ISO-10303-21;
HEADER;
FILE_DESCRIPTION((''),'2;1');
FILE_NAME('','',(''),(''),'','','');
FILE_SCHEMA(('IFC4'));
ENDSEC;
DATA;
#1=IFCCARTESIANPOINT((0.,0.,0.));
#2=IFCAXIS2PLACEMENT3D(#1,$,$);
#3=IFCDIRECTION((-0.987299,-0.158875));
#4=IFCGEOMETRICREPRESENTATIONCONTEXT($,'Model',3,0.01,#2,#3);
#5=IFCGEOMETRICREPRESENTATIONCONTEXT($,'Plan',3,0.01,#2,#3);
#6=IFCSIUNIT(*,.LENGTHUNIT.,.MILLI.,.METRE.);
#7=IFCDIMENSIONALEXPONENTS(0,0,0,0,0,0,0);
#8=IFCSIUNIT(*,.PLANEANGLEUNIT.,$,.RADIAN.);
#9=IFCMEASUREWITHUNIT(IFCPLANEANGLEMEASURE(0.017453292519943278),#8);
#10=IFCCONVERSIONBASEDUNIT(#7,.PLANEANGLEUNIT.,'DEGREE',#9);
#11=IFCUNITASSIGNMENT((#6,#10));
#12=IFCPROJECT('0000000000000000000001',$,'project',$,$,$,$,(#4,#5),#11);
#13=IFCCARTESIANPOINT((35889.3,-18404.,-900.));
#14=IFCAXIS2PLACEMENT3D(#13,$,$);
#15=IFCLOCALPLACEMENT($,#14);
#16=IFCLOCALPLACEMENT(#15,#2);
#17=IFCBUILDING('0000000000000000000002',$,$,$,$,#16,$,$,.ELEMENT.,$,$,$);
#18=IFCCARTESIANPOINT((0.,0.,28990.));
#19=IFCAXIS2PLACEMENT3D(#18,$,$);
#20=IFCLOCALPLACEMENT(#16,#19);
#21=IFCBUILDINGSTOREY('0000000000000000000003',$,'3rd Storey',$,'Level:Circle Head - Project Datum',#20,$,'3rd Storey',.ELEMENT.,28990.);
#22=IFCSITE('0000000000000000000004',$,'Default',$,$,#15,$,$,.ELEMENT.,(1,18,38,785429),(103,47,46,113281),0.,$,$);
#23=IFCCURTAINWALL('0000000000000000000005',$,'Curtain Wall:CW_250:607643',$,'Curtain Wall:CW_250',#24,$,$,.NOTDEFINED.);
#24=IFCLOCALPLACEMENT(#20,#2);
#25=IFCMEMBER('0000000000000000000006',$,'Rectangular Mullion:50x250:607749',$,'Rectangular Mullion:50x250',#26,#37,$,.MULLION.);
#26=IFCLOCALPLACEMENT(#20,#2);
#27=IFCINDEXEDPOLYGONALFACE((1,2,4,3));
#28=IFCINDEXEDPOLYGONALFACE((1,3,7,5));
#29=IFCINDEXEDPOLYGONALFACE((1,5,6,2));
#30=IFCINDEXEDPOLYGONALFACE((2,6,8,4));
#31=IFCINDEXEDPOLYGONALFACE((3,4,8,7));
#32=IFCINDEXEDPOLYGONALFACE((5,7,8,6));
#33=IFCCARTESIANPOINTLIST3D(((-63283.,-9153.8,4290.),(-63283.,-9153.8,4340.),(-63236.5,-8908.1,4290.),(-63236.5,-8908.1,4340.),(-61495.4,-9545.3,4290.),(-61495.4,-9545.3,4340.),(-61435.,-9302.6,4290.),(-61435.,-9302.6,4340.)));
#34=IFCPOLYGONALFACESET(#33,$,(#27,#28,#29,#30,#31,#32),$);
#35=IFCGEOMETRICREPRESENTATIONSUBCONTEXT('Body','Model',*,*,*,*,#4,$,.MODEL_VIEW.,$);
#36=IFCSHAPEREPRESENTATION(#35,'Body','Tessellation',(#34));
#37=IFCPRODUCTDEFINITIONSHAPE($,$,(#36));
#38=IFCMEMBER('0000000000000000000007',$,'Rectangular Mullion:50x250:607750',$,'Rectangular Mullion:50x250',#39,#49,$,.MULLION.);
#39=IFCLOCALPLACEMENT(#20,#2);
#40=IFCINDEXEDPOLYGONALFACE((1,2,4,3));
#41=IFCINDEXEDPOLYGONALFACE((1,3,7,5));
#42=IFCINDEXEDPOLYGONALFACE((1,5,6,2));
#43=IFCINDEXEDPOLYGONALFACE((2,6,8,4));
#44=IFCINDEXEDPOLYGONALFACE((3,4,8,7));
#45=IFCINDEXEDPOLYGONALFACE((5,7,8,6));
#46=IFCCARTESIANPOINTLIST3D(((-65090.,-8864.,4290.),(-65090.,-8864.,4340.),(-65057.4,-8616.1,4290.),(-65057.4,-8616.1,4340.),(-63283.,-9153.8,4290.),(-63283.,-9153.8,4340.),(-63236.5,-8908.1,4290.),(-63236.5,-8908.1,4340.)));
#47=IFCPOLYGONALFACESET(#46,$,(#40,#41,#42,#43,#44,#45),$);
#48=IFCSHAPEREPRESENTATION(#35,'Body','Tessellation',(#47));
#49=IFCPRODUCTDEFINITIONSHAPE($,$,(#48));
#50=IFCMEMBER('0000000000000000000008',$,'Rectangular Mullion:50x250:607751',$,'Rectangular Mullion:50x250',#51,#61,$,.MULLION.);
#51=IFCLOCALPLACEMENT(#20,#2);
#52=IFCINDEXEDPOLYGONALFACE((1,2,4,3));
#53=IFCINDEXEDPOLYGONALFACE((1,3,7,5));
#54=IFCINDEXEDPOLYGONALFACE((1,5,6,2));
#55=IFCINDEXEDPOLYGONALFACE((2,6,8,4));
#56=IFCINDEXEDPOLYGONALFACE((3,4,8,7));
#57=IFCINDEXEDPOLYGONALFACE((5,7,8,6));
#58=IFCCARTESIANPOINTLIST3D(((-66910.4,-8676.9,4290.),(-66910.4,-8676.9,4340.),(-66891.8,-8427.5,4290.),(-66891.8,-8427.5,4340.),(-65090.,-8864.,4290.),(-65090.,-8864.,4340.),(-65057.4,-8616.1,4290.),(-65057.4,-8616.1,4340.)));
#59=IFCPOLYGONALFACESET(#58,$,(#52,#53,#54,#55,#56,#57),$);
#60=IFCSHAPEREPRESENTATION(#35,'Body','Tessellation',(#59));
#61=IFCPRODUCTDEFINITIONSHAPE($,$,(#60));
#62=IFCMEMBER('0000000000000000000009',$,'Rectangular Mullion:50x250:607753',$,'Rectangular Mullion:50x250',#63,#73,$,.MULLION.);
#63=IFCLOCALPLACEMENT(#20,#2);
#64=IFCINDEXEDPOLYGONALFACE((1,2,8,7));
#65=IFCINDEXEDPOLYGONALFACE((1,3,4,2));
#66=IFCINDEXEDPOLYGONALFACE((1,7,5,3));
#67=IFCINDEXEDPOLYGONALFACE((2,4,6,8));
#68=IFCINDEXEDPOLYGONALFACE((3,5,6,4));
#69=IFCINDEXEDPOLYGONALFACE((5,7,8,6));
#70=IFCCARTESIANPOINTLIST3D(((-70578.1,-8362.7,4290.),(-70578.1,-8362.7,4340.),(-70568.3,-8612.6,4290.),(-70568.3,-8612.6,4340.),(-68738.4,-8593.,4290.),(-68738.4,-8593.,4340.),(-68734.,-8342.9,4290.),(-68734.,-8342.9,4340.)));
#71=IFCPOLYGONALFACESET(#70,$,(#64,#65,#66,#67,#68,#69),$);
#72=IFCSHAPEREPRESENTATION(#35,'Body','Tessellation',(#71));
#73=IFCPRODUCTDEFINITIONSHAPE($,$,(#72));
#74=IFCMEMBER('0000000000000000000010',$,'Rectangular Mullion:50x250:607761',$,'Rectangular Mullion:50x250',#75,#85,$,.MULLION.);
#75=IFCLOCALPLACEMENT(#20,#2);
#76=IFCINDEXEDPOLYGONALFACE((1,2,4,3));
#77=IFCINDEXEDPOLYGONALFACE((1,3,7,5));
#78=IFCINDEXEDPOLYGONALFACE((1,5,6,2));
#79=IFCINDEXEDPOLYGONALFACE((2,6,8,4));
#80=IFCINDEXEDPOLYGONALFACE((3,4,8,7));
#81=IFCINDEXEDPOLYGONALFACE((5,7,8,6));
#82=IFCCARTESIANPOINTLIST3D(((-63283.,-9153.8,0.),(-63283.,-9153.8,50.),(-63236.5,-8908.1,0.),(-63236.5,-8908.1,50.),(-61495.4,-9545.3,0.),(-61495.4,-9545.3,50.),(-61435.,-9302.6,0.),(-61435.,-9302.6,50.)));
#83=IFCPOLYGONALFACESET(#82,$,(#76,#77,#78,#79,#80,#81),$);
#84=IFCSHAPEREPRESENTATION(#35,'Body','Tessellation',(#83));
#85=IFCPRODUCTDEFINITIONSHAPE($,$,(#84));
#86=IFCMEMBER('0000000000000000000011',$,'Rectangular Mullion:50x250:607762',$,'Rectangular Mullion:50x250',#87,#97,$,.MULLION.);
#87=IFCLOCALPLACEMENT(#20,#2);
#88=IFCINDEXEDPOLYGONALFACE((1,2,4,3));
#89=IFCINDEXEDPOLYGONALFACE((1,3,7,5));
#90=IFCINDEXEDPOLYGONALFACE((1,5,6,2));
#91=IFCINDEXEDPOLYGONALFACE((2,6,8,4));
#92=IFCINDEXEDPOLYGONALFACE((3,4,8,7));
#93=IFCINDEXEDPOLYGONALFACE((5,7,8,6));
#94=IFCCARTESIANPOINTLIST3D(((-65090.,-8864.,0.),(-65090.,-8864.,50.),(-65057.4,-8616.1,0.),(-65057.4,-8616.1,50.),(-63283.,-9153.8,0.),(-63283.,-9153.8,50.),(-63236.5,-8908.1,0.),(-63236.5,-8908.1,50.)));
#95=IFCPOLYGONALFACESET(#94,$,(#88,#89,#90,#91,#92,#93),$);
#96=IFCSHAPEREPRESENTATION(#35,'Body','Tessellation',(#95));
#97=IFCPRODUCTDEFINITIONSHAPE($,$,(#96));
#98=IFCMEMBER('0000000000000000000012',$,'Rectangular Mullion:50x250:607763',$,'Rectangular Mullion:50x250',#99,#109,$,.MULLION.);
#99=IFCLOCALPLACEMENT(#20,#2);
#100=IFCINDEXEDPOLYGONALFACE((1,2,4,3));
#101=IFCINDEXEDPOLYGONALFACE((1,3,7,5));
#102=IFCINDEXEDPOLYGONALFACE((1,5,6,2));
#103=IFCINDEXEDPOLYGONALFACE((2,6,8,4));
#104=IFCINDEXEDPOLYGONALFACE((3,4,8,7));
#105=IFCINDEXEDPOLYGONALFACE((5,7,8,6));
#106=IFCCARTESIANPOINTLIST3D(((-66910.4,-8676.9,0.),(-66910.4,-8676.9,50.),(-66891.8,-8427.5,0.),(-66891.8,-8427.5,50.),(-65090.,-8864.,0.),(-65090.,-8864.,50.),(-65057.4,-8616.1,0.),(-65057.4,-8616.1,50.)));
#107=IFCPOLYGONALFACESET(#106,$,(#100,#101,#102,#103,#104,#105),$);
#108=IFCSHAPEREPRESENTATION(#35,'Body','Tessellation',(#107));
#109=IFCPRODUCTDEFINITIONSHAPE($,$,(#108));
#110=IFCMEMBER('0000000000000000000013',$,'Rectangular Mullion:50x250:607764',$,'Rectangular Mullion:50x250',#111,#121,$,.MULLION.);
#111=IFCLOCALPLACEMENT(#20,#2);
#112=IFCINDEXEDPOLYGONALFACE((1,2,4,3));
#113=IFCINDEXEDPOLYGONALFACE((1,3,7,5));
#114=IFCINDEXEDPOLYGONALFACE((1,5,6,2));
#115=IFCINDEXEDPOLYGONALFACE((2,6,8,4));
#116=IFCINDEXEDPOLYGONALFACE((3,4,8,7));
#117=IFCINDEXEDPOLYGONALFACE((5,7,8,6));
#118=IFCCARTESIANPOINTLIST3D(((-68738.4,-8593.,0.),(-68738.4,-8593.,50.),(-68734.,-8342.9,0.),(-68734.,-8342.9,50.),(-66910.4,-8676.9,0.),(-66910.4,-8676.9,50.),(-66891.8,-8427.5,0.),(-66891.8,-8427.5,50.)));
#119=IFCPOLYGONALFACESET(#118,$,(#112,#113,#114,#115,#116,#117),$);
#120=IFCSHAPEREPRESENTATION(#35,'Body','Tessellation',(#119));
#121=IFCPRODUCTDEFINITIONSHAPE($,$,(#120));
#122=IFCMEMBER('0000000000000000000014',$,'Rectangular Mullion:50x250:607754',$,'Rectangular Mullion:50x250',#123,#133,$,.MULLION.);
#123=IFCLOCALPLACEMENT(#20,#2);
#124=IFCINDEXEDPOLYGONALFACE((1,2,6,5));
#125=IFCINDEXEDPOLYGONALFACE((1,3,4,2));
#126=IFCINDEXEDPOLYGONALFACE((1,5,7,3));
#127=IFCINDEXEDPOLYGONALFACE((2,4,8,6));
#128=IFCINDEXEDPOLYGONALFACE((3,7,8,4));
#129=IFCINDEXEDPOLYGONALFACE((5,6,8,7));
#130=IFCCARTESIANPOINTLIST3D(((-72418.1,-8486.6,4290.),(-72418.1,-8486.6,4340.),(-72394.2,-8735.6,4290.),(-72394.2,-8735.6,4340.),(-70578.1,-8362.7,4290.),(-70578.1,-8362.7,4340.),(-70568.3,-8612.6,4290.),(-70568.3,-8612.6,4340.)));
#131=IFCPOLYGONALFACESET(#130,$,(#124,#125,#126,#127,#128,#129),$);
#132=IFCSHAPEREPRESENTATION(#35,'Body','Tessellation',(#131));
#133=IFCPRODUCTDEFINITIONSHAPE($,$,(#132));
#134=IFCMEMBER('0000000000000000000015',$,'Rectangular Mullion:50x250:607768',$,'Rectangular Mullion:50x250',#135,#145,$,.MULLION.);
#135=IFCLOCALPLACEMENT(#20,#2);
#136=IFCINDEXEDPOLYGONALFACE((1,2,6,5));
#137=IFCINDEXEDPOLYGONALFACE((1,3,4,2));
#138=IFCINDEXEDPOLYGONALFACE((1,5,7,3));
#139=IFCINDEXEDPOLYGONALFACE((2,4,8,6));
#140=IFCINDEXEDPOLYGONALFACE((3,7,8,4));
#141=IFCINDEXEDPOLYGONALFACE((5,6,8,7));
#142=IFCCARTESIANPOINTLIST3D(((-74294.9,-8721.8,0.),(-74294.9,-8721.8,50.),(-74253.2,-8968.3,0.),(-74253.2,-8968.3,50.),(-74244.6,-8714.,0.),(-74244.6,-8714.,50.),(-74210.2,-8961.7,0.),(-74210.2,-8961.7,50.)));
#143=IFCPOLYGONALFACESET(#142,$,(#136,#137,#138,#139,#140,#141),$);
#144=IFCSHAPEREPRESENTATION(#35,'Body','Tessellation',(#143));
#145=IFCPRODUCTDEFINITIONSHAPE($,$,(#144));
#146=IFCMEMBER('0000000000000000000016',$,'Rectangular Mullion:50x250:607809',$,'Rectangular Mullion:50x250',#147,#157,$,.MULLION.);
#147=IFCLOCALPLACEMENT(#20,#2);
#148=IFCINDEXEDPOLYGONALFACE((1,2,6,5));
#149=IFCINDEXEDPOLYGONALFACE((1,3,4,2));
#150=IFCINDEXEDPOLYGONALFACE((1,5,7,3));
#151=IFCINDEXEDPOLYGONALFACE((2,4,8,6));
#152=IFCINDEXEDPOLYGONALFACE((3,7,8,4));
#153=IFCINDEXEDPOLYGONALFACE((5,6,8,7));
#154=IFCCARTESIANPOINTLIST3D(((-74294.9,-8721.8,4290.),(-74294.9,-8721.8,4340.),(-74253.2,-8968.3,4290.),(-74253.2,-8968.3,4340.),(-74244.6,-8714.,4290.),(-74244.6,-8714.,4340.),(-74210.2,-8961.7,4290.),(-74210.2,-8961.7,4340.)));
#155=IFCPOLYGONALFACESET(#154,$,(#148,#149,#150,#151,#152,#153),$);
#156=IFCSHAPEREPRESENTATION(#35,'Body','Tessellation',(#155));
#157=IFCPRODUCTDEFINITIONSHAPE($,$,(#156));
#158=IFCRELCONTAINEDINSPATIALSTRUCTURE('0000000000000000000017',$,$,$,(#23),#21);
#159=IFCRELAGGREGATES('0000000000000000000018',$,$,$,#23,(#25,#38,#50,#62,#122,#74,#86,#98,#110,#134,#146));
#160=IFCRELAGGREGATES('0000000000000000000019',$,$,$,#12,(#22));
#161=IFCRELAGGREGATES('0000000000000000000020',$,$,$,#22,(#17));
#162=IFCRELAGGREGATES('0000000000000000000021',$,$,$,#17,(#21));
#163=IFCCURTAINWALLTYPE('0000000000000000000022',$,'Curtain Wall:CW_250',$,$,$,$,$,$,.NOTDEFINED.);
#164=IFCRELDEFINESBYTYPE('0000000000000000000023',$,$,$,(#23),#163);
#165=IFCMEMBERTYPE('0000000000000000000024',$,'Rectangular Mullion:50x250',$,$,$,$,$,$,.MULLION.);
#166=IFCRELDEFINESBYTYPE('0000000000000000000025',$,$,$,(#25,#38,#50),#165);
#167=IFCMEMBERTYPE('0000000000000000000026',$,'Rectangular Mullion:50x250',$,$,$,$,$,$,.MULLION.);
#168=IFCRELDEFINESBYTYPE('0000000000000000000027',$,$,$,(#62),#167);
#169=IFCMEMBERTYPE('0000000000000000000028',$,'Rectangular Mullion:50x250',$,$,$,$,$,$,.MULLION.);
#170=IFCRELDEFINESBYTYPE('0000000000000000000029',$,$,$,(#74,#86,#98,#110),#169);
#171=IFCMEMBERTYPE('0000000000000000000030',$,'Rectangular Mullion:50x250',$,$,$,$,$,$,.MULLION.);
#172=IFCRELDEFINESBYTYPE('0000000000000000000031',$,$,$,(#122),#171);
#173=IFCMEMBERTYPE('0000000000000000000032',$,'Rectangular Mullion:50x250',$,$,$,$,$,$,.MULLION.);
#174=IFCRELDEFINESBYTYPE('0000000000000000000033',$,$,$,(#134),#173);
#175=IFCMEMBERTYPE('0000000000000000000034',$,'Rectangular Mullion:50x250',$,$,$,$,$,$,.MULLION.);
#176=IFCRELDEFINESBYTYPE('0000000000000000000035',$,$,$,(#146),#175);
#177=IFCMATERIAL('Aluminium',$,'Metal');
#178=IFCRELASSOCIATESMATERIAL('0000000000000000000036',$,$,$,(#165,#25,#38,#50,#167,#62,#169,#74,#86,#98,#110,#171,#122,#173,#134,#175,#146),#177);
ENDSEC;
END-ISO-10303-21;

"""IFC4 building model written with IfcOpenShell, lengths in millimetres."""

from ifc_helpers import new_model, entity, si_unit, converted_unit, direction, frame, origin, place, context, subcontext, project, spatial, indexed_curve, outline, extrude, source, transform, mapped, material, type_object, type_shapes, element, aggregate, save


model = new_model("IFC4")

# Units and contexts
model_context = context("Model", 3, precision=0.01, world=origin(), true_north=direction((-0.987299, -0.158875)))
plan_context = context("Plan", 3, precision=0.01, world=origin(), true_north=direction((-0.987299, -0.158875)))
body_context = subcontext(model_context, "Body", "Model", "MODEL_VIEW")
ifc_project = project(units=[si_unit("LENGTHUNIT", "METRE", prefix="MILLI"), converted_unit("PLANEANGLEUNIT", "DEGREE", entity("IfcPlaneAngleMeasure", 0.017453292519943278), si_unit("PLANEANGLEUNIT", "RADIAN"), dimensions=[0, 0, 0, 0, 0, 0, 0])], contexts=[model_context, plan_context])

# Site, building, storey
site_placement = place(None, frame((35889.3, -18404.0, -900.0)))
site = spatial("IfcSite", under=ifc_project, at=site_placement, Name="Default", CompositionType="ELEMENT", RefLatitude=(1, 18, 38, 785429), RefLongitude=(103, 47, 46, 113281), RefElevation=0.0)
building_placement = place(site_placement, origin())
building = spatial("IfcBuilding", under=site, at=building_placement, CompositionType="ELEMENT")
storey_placement = place(building_placement, frame((0.0, 0.0, 28990.0)))
storey = spatial("IfcBuildingStorey", under=building, at=storey_placement, Name="3rd Storey", ObjectType="Level:Circle Head - Project Datum", LongName="3rd Storey", CompositionType="ELEMENT", Elevation=28990.0)

# Curtain wall, members
curtain_wall_type = type_object("IfcCurtainWallType", Name="Curtain Wall:CW_250", PredefinedType="NOTDEFINED")
curtain_wall_1_placement = place(storey_placement, frame((0.0, 0.0, -28990.0)))
curtain_wall_1 = element("IfcCurtainWall", 1, at=curtain_wall_1_placement, inside=storey, type_object=curtain_wall_type, Name="Curtain Wall:CW_250:607643", ObjectType="Curtain Wall:CW_250", PredefinedType="NOTDEFINED")
ifc_material_1 = material(Name="Aluminium", Category="Metal")
member_type_1 = type_object("IfcMemberType", Name="Rectangular Mullion:50x250", PredefinedType="MULLION", material=ifc_material_1)
shared_shape_1 = source(origin(), body_context, "Body", "SweptSolid", [
    extrude(outline(indexed_curve([(-915.0, -125.0), (915.0, -125.0), (922.1, 125.0), (-922.1, 125.0), (-915.0, -125.0)], self_intersect=False)), frame((-50.0, 125.0, -915.0), z_axis=(1.0, 0.0, 0.0), x_axis=(0.0, 0.0, -1.0)), (0.0, 0.0, 1.0), 50.0),
])
type_shapes(member_type_1, [shared_shape_1])
member_1_placement = place(curtain_wall_1_placement, frame((-63283.0, -9153.8, 33330.0), z_axis=(-0.976848, 0.213934, 0.0), x_axis=(0.0, 0.0, 1.0)))
member_1 = element("IfcMember", 2, at=member_1_placement, type_object=member_type_1, material=ifc_material_1, Name="Rectangular Mullion:50x250:607749", ObjectType="Rectangular Mullion:50x250", PredefinedType="MULLION", context=body_context, shape_type="MappedRepresentation", body=[
    mapped(shared_shape_1, transform((0.0, 0.0, 0.0), scale=1.0)),
])
member_2_placement = place(curtain_wall_1_placement, frame((-65090.0, -8864.0, 33330.0), z_axis=(-0.987382, 0.158354, 0.0), x_axis=(0.0, 0.0, 1.0)))
member_2 = element("IfcMember", 3, at=member_2_placement, type_object=member_type_1, material=ifc_material_1, Name="Rectangular Mullion:50x250:607750", ObjectType="Rectangular Mullion:50x250", PredefinedType="MULLION", context=body_context, shape_type="MappedRepresentation", body=[
    mapped(shared_shape_1, transform((0.0, 0.0, 0.0), scale=1.0)),
])
member_3_placement = place(curtain_wall_1_placement, frame((-66910.4, -8676.9, 33330.0), z_axis=(-0.994757, 0.102268, 0.0), x_axis=(0.0, 0.0, 1.0)))
member_3 = element("IfcMember", 4, at=member_3_placement, type_object=member_type_1, material=ifc_material_1, Name="Rectangular Mullion:50x250:607751", ObjectType="Rectangular Mullion:50x250", PredefinedType="MULLION", context=body_context, shape_type="MappedRepresentation", body=[
    mapped(shared_shape_1, transform((0.0, 0.0, 0.0), scale=1.0)),
])
member_type_2 = type_object("IfcMemberType", Name="Rectangular Mullion:50x250", PredefinedType="MULLION", material=ifc_material_1)
shared_shape_2 = source(origin(), body_context, "Body", "SweptSolid", [
    extrude(outline(indexed_curve([(-915.0, -125.0), (915.0, -125.0), (922.1, 125.0), (-922.1, 125.0), (-915.0, -125.0)], self_intersect=False)), frame((-50.0, 125.0, -915.0), z_axis=(1.0, 0.0, 0.0), x_axis=(0.0, 0.0, -1.0)), (0.0, 0.0, 1.0), 50.0),
])
type_shapes(member_type_2, [shared_shape_2])
member_4_placement = place(curtain_wall_1_placement, frame((-70568.3, -8612.6, 33330.0), z_axis=(-0.999943, -0.010705, 0.0), x_axis=(0.0, 0.0, 1.0)))
member_4 = element("IfcMember", 5, at=member_4_placement, type_object=member_type_2, material=ifc_material_1, Name="Rectangular Mullion:50x250:607753", ObjectType="Rectangular Mullion:50x250", PredefinedType="MULLION", context=body_context, shape_type="MappedRepresentation", body=[
    mapped(shared_shape_2, transform((0.0, 0.0, 0.0), scale=1.0)),
])
member_type_3 = type_object("IfcMemberType", Name="Rectangular Mullion:50x250", PredefinedType="MULLION", material=ifc_material_1)
shared_shape_3 = source(origin(), body_context, "Body", "SweptSolid", [
    extrude(outline(indexed_curve([(-915.0, -125.0), (915.0, -125.0), (922.1, 125.0), (-922.1, 125.0), (-915.0, -125.0)], self_intersect=False)), frame((-50.0, 125.0, -915.0), z_axis=(1.0, 0.0, 0.0), x_axis=(0.0, 0.0, -1.0)), (0.0, 0.0, 1.0), 50.0),
])
type_shapes(member_type_3, [shared_shape_3])
member_5_placement = place(curtain_wall_1_placement, frame((-61495.4, -9545.3, 28990.0), z_axis=(0.976848, -0.213934, 0.0), x_axis=(0.0, 0.0, -1.0)))
member_5 = element("IfcMember", 6, at=member_5_placement, type_object=member_type_3, material=ifc_material_1, Name="Rectangular Mullion:50x250:607761", ObjectType="Rectangular Mullion:50x250", PredefinedType="MULLION", context=body_context, shape_type="MappedRepresentation", body=[
    mapped(shared_shape_3, transform((0.0, 0.0, 0.0), scale=1.0)),
])
member_6_placement = place(curtain_wall_1_placement, frame((-63283.0, -9153.8, 28990.0), z_axis=(0.987382, -0.158354, 0.0), x_axis=(0.0, 0.0, -1.0)))
member_6 = element("IfcMember", 7, at=member_6_placement, type_object=member_type_3, material=ifc_material_1, Name="Rectangular Mullion:50x250:607762", ObjectType="Rectangular Mullion:50x250", PredefinedType="MULLION", context=body_context, shape_type="MappedRepresentation", body=[
    mapped(shared_shape_3, transform((0.0, 0.0, 0.0), scale=1.0)),
])
member_7_placement = place(curtain_wall_1_placement, frame((-65090.0, -8864.0, 28990.0), z_axis=(0.994757, -0.102268, 0.0), x_axis=(0.0, 0.0, -1.0)))
member_7 = element("IfcMember", 8, at=member_7_placement, type_object=member_type_3, material=ifc_material_1, Name="Rectangular Mullion:50x250:607763", ObjectType="Rectangular Mullion:50x250", PredefinedType="MULLION", context=body_context, shape_type="MappedRepresentation", body=[
    mapped(shared_shape_3, transform((0.0, 0.0, 0.0), scale=1.0)),
])
member_8_placement = place(curtain_wall_1_placement, frame((-66910.4, -8676.9, 28990.0), z_axis=(0.998948, -0.045855, 0.0), x_axis=(0.0, 0.0, -1.0)))
member_8 = element("IfcMember", 9, at=member_8_placement, type_object=member_type_3, material=ifc_material_1, Name="Rectangular Mullion:50x250:607764", ObjectType="Rectangular Mullion:50x250", PredefinedType="MULLION", context=body_context, shape_type="MappedRepresentation", body=[
    mapped(shared_shape_3, transform((0.0, 0.0, 0.0), scale=1.0)),
])
member_type_4 = type_object("IfcMemberType", Name="Rectangular Mullion:50x250", PredefinedType="MULLION", material=ifc_material_1)
shared_shape_4 = source(origin(), body_context, "Body", "SweptSolid", [
    extrude(outline(indexed_curve([(-915.0, -125.0), (915.0, -125.0), (922.1, 125.0), (-922.1, 125.0), (-915.0, -125.0)], self_intersect=False)), frame((-50.0, 125.0, -915.0), z_axis=(1.0, 0.0, 0.0), x_axis=(0.0, 0.0, -1.0)), (0.0, 0.0, 1.0), 50.0),
])
type_shapes(member_type_4, [shared_shape_4])
member_9_placement = place(curtain_wall_1_placement, frame((-72394.2, -8735.6, 33330.0), z_axis=(-0.997737, -0.067231, 0.0), x_axis=(0.0, 0.0, 1.0)))
member_9 = element("IfcMember", 10, at=member_9_placement, type_object=member_type_4, material=ifc_material_1, Name="Rectangular Mullion:50x250:607754", ObjectType="Rectangular Mullion:50x250", PredefinedType="MULLION", context=body_context, shape_type="MappedRepresentation", body=[
    mapped(shared_shape_4, transform((0.0, 0.0, 0.0), scale=1.0)),
])
member_type_5 = type_object("IfcMemberType", Name="Rectangular Mullion:50x250", PredefinedType="MULLION", material=ifc_material_1)
shared_shape_5 = source(origin(), body_context, "Body", "SweptSolid", [
    extrude(outline(indexed_curve([(-21.8, -125.0), (21.8, -125.0), (25.4, 125.0), (-25.4, 125.0), (-21.8, -125.0)], self_intersect=False)), frame((-50.0, 125.0, -21.8), z_axis=(1.0, 0.0, 0.0), x_axis=(0.0, 0.0, -1.0)), (0.0, 0.0, 1.0), 50.0),
])
type_shapes(member_type_5, [shared_shape_5])
member_10_placement = place(curtain_wall_1_placement, frame((-74210.2, -8961.7, 28990.0), z_axis=(0.988346, 0.152225, 0.0), x_axis=(0.0, 0.0, -1.0)))
member_10 = element("IfcMember", 11, at=member_10_placement, type_object=member_type_5, material=ifc_material_1, Name="Rectangular Mullion:50x250:607768", ObjectType="Rectangular Mullion:50x250", PredefinedType="MULLION", context=body_context, shape_type="MappedRepresentation", body=[
    mapped(shared_shape_5, transform((0.0, 0.0, 0.0), scale=1.0)),
])
member_type_6 = type_object("IfcMemberType", Name="Rectangular Mullion:50x250", PredefinedType="MULLION", material=ifc_material_1)
shared_shape_6 = source(origin(), body_context, "Body", "SweptSolid", [
    extrude(outline(indexed_curve([(-21.8, -125.0), (21.8, -125.0), (25.4, 125.0), (-25.4, 125.0), (-21.8, -125.0)], self_intersect=False)), frame((-50.0, 125.0, -21.8), z_axis=(1.0, 0.0, 0.0), x_axis=(0.0, 0.0, -1.0)), (0.0, 0.0, 1.0), 50.0),
])
type_shapes(member_type_6, [shared_shape_6])
member_11_placement = place(curtain_wall_1_placement, frame((-74253.2, -8968.3, 33330.0), z_axis=(-0.988346, -0.152225, 0.0), x_axis=(0.0, 0.0, 1.0)))
member_11 = element("IfcMember", 12, at=member_11_placement, type_object=member_type_6, material=ifc_material_1, Name="Rectangular Mullion:50x250:607809", ObjectType="Rectangular Mullion:50x250", PredefinedType="MULLION", context=body_context, shape_type="MappedRepresentation", body=[
    mapped(shared_shape_6, transform((0.0, 0.0, 0.0), scale=1.0)),
])

aggregate(curtain_wall_1, [member_1, member_2, member_3, member_4, member_9, member_5, member_6, member_7, member_8, member_10, member_11])

save(model, "model.ifc")
